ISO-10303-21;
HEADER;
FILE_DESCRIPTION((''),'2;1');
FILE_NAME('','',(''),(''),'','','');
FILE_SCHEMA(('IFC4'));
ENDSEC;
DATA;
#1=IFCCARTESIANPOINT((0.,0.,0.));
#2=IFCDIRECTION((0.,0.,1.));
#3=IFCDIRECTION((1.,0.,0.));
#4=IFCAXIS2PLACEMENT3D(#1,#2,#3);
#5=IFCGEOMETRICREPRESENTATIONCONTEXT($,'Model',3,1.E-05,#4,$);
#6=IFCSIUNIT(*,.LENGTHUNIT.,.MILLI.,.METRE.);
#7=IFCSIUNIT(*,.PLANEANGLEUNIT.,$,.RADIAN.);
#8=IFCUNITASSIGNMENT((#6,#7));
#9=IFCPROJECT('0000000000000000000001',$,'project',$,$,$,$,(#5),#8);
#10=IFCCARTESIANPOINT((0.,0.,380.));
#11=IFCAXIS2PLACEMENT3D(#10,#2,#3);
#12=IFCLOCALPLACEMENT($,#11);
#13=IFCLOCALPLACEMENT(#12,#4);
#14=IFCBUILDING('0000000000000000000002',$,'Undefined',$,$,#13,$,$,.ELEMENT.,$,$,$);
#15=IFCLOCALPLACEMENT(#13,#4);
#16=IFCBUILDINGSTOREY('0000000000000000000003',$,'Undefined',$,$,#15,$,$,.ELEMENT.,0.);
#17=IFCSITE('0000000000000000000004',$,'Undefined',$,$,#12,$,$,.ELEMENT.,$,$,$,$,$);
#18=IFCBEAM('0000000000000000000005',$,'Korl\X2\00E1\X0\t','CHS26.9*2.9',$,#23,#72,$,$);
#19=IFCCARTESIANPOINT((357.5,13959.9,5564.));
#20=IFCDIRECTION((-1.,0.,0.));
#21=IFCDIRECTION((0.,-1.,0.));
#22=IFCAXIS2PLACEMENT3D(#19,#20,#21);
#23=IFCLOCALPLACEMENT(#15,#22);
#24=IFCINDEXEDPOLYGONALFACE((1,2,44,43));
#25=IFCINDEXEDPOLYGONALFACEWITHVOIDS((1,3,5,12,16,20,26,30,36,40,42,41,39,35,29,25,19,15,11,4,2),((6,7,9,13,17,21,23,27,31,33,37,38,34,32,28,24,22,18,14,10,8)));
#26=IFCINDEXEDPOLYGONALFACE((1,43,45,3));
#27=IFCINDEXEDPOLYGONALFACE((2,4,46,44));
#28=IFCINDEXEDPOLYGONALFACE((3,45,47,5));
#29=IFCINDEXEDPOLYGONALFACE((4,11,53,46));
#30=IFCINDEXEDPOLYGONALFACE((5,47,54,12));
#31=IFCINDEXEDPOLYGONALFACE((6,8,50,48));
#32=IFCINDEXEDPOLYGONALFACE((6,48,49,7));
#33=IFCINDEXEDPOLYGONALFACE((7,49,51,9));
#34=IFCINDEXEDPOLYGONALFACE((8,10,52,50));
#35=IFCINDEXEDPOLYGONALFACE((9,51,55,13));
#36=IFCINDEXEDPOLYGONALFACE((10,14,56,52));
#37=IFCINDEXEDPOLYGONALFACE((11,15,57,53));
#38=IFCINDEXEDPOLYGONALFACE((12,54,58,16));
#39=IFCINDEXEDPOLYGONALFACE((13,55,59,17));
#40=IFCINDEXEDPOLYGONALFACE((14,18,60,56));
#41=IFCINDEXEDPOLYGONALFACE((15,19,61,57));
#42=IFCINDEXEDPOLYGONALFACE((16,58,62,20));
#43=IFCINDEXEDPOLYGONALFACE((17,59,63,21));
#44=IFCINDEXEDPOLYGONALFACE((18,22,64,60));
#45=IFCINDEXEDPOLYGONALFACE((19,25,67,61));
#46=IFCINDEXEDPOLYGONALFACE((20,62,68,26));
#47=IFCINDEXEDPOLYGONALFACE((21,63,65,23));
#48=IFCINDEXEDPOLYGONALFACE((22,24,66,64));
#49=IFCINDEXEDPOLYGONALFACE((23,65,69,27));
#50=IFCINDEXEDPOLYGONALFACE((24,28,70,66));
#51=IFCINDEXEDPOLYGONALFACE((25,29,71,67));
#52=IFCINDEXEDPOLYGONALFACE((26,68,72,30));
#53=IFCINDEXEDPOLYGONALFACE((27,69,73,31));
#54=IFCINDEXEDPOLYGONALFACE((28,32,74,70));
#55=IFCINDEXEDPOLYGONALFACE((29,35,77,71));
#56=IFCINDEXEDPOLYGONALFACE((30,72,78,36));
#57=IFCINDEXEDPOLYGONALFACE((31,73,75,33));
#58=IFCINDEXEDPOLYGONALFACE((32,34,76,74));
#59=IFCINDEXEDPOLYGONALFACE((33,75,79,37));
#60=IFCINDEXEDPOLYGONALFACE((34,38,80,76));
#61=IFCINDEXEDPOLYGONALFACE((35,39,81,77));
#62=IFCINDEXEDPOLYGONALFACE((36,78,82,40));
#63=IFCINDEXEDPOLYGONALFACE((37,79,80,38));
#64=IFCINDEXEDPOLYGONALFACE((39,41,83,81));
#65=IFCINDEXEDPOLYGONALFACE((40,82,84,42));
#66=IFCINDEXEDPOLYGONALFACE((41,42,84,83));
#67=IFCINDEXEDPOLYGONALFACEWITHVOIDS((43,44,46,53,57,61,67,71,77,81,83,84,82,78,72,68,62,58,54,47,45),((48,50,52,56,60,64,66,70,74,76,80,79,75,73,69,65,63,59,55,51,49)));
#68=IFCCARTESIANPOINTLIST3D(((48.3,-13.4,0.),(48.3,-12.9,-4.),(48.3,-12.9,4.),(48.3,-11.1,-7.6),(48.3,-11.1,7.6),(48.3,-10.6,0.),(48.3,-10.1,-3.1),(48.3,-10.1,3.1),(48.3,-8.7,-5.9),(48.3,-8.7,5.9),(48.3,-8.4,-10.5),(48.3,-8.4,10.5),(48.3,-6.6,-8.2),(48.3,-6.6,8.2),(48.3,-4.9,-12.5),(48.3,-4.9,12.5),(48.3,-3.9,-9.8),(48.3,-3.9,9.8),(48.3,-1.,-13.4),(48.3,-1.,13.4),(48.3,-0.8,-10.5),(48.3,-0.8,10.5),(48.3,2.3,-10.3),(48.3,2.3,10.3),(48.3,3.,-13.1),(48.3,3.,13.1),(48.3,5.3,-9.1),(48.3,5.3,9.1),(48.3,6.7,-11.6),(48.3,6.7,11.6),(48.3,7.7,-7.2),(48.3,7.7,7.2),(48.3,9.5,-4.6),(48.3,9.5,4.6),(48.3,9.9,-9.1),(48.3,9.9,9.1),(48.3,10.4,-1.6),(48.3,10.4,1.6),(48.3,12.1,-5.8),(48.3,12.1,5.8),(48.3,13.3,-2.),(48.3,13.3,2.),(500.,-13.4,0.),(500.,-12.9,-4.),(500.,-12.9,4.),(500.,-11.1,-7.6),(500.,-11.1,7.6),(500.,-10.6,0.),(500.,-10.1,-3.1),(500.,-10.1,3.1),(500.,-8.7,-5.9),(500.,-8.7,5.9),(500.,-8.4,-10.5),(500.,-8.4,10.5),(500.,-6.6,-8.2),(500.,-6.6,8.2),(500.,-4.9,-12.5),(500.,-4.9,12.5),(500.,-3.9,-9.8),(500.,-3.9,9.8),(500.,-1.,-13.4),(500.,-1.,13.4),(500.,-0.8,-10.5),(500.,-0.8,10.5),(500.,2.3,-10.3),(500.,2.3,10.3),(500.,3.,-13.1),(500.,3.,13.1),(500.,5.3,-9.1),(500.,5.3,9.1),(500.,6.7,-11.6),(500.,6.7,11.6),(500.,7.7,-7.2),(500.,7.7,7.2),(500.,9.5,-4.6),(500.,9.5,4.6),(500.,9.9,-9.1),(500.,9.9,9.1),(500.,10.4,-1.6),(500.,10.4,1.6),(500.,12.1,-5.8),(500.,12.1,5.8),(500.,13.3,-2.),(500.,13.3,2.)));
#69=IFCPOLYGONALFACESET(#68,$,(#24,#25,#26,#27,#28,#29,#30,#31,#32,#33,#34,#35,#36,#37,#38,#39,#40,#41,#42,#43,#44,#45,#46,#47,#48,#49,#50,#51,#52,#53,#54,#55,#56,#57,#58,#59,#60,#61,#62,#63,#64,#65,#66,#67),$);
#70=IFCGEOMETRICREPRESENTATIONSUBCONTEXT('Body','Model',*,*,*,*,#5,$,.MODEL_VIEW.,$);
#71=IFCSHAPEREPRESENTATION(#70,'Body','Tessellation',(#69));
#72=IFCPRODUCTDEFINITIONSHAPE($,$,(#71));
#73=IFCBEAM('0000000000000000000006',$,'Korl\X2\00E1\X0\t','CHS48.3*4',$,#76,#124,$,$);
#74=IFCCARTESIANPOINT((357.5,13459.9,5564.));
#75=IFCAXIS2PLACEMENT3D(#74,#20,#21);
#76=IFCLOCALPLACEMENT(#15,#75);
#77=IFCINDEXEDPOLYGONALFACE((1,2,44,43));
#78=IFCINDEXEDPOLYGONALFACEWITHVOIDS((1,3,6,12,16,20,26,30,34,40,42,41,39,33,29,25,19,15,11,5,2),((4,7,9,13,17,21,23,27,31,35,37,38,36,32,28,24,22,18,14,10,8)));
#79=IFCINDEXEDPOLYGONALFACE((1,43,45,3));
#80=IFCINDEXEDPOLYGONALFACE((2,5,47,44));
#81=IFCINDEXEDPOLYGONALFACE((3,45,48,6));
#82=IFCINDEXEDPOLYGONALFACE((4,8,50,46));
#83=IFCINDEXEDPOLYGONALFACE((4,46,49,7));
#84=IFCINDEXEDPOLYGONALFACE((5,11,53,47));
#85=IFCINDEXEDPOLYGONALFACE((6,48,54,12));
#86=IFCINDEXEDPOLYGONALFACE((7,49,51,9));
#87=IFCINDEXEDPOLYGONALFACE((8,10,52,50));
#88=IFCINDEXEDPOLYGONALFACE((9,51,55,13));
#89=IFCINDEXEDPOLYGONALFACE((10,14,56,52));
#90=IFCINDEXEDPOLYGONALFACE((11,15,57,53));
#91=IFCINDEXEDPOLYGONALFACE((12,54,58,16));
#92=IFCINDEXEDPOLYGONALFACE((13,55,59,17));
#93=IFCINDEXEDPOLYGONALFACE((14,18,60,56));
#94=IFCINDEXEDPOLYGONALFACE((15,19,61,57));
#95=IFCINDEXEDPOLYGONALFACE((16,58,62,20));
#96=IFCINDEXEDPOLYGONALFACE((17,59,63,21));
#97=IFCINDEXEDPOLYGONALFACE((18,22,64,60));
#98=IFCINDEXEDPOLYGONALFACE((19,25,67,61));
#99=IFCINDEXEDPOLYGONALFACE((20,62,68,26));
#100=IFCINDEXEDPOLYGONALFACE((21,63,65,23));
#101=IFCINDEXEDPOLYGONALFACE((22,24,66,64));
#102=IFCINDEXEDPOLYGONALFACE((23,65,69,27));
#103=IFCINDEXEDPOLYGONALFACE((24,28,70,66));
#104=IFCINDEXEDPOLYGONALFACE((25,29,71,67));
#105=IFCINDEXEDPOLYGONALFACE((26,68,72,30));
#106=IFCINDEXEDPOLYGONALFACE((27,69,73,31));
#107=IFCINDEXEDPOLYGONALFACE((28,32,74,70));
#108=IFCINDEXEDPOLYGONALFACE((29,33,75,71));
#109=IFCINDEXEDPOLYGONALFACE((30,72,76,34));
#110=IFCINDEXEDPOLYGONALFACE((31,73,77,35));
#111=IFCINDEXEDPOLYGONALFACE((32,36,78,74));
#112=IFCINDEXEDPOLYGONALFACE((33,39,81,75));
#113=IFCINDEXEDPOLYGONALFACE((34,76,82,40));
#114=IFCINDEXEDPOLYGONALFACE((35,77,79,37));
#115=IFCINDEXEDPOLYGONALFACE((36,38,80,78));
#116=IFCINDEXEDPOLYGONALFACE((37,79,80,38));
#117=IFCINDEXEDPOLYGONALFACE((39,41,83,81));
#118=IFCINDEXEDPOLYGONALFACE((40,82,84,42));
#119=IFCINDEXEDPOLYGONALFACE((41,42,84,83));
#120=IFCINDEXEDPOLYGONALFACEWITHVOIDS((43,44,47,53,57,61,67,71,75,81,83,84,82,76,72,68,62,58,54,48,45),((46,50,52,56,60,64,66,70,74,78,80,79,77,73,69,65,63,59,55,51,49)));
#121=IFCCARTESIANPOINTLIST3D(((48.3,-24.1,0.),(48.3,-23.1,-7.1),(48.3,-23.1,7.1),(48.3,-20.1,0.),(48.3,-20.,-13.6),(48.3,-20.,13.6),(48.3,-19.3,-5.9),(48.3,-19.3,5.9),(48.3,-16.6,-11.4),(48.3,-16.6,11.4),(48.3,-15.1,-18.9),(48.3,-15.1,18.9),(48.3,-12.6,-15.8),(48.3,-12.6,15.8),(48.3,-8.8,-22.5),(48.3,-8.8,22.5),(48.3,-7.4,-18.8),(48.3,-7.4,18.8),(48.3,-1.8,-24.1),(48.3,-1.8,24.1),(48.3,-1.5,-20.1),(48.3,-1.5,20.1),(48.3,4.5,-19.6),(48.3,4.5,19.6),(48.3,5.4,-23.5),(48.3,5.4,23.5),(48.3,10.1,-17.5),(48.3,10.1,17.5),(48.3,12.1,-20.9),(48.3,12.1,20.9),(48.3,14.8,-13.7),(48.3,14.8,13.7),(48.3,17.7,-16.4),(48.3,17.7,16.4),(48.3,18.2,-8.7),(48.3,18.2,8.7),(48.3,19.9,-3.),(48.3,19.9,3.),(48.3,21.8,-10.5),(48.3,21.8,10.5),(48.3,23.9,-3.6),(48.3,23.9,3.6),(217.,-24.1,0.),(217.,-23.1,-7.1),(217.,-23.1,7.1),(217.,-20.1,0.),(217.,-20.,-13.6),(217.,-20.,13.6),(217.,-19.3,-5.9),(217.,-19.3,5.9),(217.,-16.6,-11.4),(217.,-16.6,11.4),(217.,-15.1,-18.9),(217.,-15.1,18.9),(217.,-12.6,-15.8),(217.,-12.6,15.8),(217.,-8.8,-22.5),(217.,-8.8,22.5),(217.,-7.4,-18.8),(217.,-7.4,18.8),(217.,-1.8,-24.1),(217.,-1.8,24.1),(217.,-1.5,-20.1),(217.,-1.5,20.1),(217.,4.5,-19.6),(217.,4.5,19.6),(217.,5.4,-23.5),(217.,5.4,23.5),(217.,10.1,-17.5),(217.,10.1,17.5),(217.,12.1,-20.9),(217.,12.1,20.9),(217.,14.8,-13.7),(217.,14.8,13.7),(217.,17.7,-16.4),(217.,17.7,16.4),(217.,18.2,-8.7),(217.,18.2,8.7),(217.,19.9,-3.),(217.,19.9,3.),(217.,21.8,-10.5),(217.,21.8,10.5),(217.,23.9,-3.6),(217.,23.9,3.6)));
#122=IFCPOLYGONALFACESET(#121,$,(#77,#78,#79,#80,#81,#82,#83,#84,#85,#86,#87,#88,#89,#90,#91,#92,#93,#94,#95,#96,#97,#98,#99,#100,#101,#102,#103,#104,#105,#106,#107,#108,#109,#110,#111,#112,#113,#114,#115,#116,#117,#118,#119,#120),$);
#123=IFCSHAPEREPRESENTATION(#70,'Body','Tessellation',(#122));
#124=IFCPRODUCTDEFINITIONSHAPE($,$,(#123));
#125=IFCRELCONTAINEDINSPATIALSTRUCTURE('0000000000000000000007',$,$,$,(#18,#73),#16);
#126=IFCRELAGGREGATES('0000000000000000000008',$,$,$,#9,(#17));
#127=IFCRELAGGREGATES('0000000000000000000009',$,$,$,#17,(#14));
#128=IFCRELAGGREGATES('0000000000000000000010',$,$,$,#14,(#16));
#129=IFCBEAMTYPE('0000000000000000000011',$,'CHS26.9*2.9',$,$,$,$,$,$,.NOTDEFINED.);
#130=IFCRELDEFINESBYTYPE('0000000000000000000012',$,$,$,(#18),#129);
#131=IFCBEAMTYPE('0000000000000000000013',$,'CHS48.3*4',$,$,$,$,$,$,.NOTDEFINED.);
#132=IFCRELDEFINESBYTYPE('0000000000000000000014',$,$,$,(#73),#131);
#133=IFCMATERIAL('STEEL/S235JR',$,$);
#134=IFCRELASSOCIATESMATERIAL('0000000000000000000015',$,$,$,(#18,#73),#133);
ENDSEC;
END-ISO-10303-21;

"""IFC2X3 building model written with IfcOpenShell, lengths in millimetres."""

from ifc_helpers import new_model, si_unit, frame, origin_with_axes, origin_2d_with_axis, place, context, subcontext, project, spatial, hollow_circle, extrude, clip, halfspace, material, type_object, element, save


model = new_model("IFC2X3")

# Units and contexts
model_context = context("Model", 3, precision=1e-05, world=origin_with_axes())
body_context = subcontext(model_context, "Body", "Model", "MODEL_VIEW")
ifc_project = project(units=[si_unit("LENGTHUNIT", "METRE", prefix="MILLI"), si_unit("PLANEANGLEUNIT", "RADIAN")], contexts=[model_context])

# Site, building, storey
site_placement = place(None, frame((0.0, 0.0, 380.0), z_axis=(0.0, 0.0, 1.0), x_axis=(1.0, 0.0, 0.0)))
site = spatial("IfcSite", under=ifc_project, at=site_placement, Name="Undefined", CompositionType="ELEMENT")
building_placement = place(site_placement, origin_with_axes())
building = spatial("IfcBuilding", under=site, at=building_placement, Name="Undefined", CompositionType="ELEMENT")
storey_placement = place(building_placement, origin_with_axes())
storey = spatial("IfcBuildingStorey", under=building, at=storey_placement, Name="Undefined", CompositionType="ELEMENT", Elevation=0.0)

# Shared definitions
ifc_material_1 = material(Name="STEEL/S235JR")

# Beams
beam_type_1 = type_object("IfcBeamType", Name="CHS26.9*2.9", PredefinedType="NOTDEFINED")
beam_1_placement = place(storey_placement, frame((357.5, 13959.9, 5564.0), z_axis=(-1.0, 0.0, 0.0), x_axis=(0.0, -1.0, 0.0)))
element("IfcBeam", 1, at=beam_1_placement, inside=storey, type_object=beam_type_1, material=ifc_material_1, Name="Korlát", Description="CHS26.9*2.9", context=body_context, shape_type="Clipping", body=[
    clip(clip(extrude(hollow_circle(Radius=13.4, WallThickness=2.9, at=origin_2d_with_axis()), frame((500.0, 0.0, 0.0), z_axis=(-1.0, 0.0, 0.0), x_axis=(0.0, -1.0, 0.0)), (0.0, 0.0, 1.0), 500.0), halfspace(frame((500.0, -76.9, 26.9), z_axis=(1.0, 0.0, 0.0), x_axis=(0.0, 1.0, 0.0)), False)), halfspace(frame((48.3, -76.9, 26.9), z_axis=(1.0, 0.0, 0.0), x_axis=(0.0, 1.0, 0.0)), True)),
])
beam_type_2 = type_object("IfcBeamType", Name="CHS48.3*4", PredefinedType="NOTDEFINED")
beam_2_placement = place(storey_placement, frame((357.5, 13459.9, 5564.0), z_axis=(-1.0, 0.0, 0.0), x_axis=(0.0, -1.0, 0.0)))
element("IfcBeam", 2, at=beam_2_placement, inside=storey, type_object=beam_type_2, material=ifc_material_1, Name="Korlát", Description="CHS48.3*4", context=body_context, shape_type="Clipping", body=[
    clip(extrude(hollow_circle(Radius=24.1, WallThickness=4.0, at=origin_2d_with_axis()), frame((217.0, 0.0, 0.0), z_axis=(-1.0, 0.0, 0.0), x_axis=(0.0, -1.0, 0.0)), (0.0, 0.0, 1.0), 217.1), halfspace(frame((48.3, -76.9, 26.9), z_axis=(1.0, 0.0, 0.0), x_axis=(0.0, 1.0, 0.0)), True)),
])

save(model, "model.ifc")
